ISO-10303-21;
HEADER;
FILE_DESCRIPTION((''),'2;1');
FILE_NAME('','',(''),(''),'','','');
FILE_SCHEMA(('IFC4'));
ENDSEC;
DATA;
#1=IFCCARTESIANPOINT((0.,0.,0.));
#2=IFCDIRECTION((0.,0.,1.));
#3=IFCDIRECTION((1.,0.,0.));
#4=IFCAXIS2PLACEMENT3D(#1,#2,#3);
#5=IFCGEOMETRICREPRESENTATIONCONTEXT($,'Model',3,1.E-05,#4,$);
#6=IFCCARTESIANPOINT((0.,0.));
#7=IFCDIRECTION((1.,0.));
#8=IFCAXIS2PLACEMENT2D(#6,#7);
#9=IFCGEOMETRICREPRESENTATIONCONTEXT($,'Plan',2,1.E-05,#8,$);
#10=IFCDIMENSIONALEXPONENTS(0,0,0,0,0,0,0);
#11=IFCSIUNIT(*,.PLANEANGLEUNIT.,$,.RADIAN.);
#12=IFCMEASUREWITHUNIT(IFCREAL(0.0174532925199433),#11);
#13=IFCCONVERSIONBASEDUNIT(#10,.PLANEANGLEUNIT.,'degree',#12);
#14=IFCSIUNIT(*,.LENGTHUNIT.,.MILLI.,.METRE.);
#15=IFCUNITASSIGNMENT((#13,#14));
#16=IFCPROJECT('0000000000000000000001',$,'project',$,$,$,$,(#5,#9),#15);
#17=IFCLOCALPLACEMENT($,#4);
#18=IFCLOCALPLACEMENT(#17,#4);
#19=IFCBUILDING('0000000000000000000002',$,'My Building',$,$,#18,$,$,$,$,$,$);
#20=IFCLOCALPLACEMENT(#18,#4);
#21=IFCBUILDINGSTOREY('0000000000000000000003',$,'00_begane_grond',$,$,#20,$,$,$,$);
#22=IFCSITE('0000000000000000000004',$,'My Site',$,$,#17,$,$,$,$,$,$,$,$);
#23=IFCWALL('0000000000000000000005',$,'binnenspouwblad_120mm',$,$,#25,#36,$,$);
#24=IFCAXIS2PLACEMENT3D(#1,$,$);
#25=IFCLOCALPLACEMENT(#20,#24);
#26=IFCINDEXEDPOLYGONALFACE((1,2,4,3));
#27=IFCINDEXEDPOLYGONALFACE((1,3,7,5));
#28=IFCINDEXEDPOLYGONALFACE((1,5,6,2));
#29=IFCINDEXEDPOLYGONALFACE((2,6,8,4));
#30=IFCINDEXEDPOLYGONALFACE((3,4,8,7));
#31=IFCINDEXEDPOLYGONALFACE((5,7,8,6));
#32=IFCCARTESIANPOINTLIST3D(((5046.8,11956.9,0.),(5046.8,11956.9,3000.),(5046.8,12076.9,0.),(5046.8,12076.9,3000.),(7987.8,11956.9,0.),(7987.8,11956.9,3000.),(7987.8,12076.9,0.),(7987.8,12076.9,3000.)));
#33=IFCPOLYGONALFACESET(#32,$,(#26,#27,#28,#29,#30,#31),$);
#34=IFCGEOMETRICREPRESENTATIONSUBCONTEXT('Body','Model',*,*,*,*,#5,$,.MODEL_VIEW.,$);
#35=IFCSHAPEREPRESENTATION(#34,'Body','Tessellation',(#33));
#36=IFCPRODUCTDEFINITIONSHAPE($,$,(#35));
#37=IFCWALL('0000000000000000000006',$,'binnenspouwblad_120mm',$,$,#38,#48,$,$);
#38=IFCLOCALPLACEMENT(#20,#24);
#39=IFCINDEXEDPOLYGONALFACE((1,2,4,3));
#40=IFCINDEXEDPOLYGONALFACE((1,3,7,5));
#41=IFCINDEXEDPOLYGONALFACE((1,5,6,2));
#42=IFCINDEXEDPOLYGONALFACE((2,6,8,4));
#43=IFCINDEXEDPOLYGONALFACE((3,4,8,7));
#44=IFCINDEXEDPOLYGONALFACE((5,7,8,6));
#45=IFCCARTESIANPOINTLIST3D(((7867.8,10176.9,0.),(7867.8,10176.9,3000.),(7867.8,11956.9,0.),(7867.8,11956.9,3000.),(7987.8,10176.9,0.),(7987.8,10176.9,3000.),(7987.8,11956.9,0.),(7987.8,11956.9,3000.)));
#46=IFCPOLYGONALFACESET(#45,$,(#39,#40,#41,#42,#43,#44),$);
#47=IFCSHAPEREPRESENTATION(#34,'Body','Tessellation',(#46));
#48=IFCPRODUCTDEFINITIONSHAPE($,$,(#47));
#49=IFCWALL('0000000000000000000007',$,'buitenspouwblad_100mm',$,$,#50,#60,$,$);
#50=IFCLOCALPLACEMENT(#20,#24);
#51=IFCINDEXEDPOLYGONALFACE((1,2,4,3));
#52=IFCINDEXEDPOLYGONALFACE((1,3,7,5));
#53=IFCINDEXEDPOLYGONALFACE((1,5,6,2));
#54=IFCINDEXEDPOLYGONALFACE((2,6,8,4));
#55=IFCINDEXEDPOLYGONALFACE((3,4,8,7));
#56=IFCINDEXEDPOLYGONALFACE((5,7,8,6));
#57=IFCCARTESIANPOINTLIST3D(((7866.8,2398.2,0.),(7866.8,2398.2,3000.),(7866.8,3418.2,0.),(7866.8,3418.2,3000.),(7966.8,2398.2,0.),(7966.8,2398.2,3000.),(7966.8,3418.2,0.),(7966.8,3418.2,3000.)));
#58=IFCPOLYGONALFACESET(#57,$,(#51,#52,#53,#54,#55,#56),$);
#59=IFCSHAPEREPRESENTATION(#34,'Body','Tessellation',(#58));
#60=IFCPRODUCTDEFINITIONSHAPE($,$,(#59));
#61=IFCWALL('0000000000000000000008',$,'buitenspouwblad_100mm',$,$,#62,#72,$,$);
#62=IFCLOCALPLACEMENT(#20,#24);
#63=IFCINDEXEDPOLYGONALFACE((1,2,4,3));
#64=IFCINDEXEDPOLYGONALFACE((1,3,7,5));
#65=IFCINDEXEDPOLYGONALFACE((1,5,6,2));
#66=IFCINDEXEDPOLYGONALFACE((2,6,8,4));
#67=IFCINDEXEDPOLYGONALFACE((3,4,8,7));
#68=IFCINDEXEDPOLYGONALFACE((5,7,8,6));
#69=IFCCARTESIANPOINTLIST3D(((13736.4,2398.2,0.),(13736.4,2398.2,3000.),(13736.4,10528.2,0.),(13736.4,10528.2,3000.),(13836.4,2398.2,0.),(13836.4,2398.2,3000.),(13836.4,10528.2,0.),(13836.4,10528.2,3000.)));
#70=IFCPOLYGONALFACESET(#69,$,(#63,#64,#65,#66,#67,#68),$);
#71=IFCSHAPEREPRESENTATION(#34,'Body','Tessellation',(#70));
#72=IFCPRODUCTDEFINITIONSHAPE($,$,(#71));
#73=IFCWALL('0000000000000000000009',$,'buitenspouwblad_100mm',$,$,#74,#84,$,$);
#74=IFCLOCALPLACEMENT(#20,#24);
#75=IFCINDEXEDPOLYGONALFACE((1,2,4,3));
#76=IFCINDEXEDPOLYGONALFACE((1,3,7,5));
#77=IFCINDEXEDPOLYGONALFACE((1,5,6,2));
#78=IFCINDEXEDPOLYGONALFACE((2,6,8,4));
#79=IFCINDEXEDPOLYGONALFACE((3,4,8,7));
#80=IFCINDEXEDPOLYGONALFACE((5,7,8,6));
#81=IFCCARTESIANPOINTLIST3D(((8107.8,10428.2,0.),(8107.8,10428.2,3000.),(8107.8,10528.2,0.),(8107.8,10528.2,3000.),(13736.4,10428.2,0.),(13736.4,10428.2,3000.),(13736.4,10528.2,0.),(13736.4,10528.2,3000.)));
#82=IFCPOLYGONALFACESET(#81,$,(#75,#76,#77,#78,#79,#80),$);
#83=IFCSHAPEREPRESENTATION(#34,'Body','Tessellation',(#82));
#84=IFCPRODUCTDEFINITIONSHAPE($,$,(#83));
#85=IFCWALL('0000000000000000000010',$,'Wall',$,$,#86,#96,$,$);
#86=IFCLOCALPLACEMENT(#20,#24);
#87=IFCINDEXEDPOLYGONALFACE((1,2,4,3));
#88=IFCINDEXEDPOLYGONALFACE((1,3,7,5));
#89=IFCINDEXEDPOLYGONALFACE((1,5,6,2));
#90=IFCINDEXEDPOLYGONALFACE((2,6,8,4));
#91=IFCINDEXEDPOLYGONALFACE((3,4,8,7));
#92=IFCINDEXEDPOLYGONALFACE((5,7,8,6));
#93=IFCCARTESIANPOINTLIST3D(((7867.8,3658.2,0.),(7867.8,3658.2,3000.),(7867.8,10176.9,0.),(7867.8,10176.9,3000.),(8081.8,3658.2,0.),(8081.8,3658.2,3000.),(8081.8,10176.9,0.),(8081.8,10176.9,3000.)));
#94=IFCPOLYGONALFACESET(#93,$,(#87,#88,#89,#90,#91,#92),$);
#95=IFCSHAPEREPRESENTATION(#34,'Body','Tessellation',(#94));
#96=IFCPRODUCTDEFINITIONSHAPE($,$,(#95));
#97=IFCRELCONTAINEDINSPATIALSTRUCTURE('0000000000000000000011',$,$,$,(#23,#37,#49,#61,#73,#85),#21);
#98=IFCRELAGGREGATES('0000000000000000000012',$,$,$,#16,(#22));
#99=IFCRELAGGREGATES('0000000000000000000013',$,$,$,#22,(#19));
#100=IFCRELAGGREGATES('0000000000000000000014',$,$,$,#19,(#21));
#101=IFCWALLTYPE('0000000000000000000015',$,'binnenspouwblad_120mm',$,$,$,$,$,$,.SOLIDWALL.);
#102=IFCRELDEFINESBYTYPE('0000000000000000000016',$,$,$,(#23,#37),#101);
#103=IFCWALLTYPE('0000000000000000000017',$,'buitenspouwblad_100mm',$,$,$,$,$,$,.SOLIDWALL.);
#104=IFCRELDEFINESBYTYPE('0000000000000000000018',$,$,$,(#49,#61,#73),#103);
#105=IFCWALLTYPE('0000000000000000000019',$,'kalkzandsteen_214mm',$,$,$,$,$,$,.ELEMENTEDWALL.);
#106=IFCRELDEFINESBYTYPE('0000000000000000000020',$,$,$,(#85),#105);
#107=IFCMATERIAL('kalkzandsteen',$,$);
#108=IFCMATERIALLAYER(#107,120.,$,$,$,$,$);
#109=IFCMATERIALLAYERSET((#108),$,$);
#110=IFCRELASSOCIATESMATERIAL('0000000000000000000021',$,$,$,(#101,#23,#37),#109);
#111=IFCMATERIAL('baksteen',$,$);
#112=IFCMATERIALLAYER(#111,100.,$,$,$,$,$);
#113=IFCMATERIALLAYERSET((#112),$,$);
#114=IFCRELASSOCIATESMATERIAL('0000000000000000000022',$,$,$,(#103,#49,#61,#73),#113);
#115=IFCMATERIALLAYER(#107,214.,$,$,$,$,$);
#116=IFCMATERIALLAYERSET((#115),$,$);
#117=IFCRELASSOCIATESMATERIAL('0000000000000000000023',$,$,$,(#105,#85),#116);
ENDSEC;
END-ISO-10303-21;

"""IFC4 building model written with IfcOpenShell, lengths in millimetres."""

from ifc_helpers import new_model, entity, si_unit, converted_unit, frame, origin_with_axes, origin_2d_with_axis, place, context, subcontext, project, spatial, indexed_curve, outline, extrude, material, layer, layer_set, layer_usage, type_object, element, save


model = new_model("IFC4")

# Units and contexts
model_context = context("Model", 3, precision=1e-05, world=origin_with_axes())
plan_context = context("Plan", 2, precision=1e-05, world=origin_2d_with_axis())
body_context = subcontext(model_context, "Body", "Model", "MODEL_VIEW")
ifc_project = project(units=[converted_unit("PLANEANGLEUNIT", "degree", entity("IfcReal", 0.0174532925199433), si_unit("PLANEANGLEUNIT", "RADIAN"), dimensions=[0, 0, 0, 0, 0, 0, 0]), si_unit("LENGTHUNIT", "METRE", prefix="MILLI")], contexts=[model_context, plan_context])

# Site, building, storey
site_placement = place(None, origin_with_axes())
site = spatial("IfcSite", under=ifc_project, at=site_placement, Name="My Site")
building_placement = place(site_placement, origin_with_axes())
building = spatial("IfcBuilding", under=site, at=building_placement, Name="My Building")
storey_placement = place(building_placement, origin_with_axes())
storey = spatial("IfcBuildingStorey", under=building, at=storey_placement, Name="00_begane_grond")

# Walls
ifc_material_1 = material(Name="kalkzandsteen")
ifc_layer_1 = layer(ifc_material_1, 120.0)
ifc_layer_set_1 = layer_set([ifc_layer_1])
wall_type_1 = type_object("IfcWallType", Name="binnenspouwblad_120mm", PredefinedType="SOLIDWALL", material=ifc_layer_set_1)
ifc_layer_usage_1 = layer_usage(ifc_layer_set_1, "AXIS2", "POSITIVE", 0.0)
wall_1_placement = place(storey_placement, frame((7987.8, 12076.9, 0.0), z_axis=(0.0, 0.0, 1.0), x_axis=(-1.0, 0.000002, 0.0)))
element("IfcWall", 1, at=wall_1_placement, inside=storey, type_object=wall_type_1, material=ifc_layer_usage_1, Name="binnenspouwblad_120mm", context=body_context, shape_type="SweptSolid", body=[
    extrude(outline(indexed_curve([(0.0, 0.0), (0.0, 120.0), (2941.0, 120.0), (2941.0, 0.0), (0.0, 0.0)], self_intersect=False)), origin_with_axes(), (0.0, 0.0, 1.0), 3000.0),
])
ifc_layer_usage_2 = layer_usage(ifc_layer_set_1, "AXIS2", "POSITIVE", 0.0)
wall_2_placement = place(storey_placement, frame((7987.8, 10176.9, 0.0), z_axis=(0.0, 0.0, 1.0), x_axis=(0.000002, 1.0, 0.0)))
element("IfcWall", 2, at=wall_2_placement, inside=storey, type_object=wall_type_1, material=ifc_layer_usage_2, Name="binnenspouwblad_120mm", context=body_context, shape_type="SweptSolid", body=[
    extrude(outline(indexed_curve([(0.0, 0.0), (0.0, 120.0), (1780.0, 120.0), (1780.0, 0.0), (0.0, 0.0)], self_intersect=False)), origin_with_axes(), (0.0, 0.0, 1.0), 3000.0),
])
ifc_material_2 = material(Name="baksteen")
ifc_layer_2 = layer(ifc_material_2, 100.0)
ifc_layer_set_2 = layer_set([ifc_layer_2])
ifc_layer_usage_3 = layer_usage(ifc_layer_set_2, "AXIS2", "POSITIVE", 0.0)
wall_type_2 = type_object("IfcWallType", Name="buitenspouwblad_100mm", PredefinedType="SOLIDWALL", material=ifc_layer_set_2)
wall_3_placement = place(storey_placement, frame((7966.8, 2398.2, 0.0), z_axis=(0.0, 0.0, 1.0), x_axis=(0.000001, 1.0, 0.0)))
element("IfcWall", 3, at=wall_3_placement, inside=storey, type_object=wall_type_2, material=ifc_layer_usage_3, Name="buitenspouwblad_100mm", context=body_context, shape_type="SweptSolid", body=[
    extrude(outline(indexed_curve([(0.0, 0.0), (0.0, 100.0), (1020.0, 100.0), (1020.0, 0.0), (0.0, 0.0)], self_intersect=False)), origin_with_axes(), (0.0, 0.0, 1.0), 3000.0),
])
ifc_layer_usage_4 = layer_usage(ifc_layer_set_2, "AXIS2", "POSITIVE", 0.0)
wall_4_placement = place(storey_placement, frame((13836.4, 2398.2, 0.0), z_axis=(0.0, 0.0, 1.0), x_axis=(0.0, 1.0, 0.0)))
element("IfcWall", 4, at=wall_4_placement, inside=storey, type_object=wall_type_2, material=ifc_layer_usage_4, Name="buitenspouwblad_100mm", context=body_context, shape_type="SweptSolid", body=[
    extrude(outline(indexed_curve([(0.0, 0.0), (0.0, 100.0), (8130.0, 100.0), (8130.0, 0.0), (0.0, 0.0)], self_intersect=False)), origin_with_axes(), (0.0, 0.0, 1.0), 3000.0),
])
ifc_layer_usage_5 = layer_usage(ifc_layer_set_2, "AXIS2", "POSITIVE", 0.0)
wall_5_placement = place(storey_placement, frame((13736.4, 10528.2, 0.0), z_axis=(0.0, 0.0, 1.0), x_axis=(-1.0, 0.0, 0.0)))
element("IfcWall", 5, at=wall_5_placement, inside=storey, type_object=wall_type_2, material=ifc_layer_usage_5, Name="buitenspouwblad_100mm", context=body_context, shape_type="SweptSolid", body=[
    extrude(outline(indexed_curve([(0.0, 0.0), (0.0, 100.0), (5628.7, 100.0), (5628.7, 0.0), (0.0, 0.0)], self_intersect=False)), origin_with_axes(), (0.0, 0.0, 1.0), 3000.0),
])
ifc_layer_3 = layer(ifc_material_1, 214.0)
ifc_layer_set_3 = layer_set([ifc_layer_3])
ifc_layer_usage_6 = layer_usage(ifc_layer_set_3, "AXIS2", "POSITIVE", 0.0)
wall_type_3 = type_object("IfcWallType", Name="kalkzandsteen_214mm", PredefinedType="ELEMENTEDWALL", material=ifc_layer_set_3)
wall_6_placement = place(storey_placement, frame((7867.8, 10176.9, 0.0), z_axis=(0.0, 0.0, 1.0), x_axis=(-0.000001, -1.0, 0.0)))
element("IfcWall", 6, at=wall_6_placement, inside=storey, type_object=wall_type_3, material=ifc_layer_usage_6, Name="Wall", context=body_context, shape_type="SweptSolid", body=[
    extrude(outline(indexed_curve([(0.0, 0.0), (0.0, 214.0), (6518.8, 214.0), (6518.8, 0.0), (0.0, 0.0)], self_intersect=False)), origin_with_axes(), (0.0, 0.0, 1.0), 3000.0),
])

save(model, "model.ifc")
